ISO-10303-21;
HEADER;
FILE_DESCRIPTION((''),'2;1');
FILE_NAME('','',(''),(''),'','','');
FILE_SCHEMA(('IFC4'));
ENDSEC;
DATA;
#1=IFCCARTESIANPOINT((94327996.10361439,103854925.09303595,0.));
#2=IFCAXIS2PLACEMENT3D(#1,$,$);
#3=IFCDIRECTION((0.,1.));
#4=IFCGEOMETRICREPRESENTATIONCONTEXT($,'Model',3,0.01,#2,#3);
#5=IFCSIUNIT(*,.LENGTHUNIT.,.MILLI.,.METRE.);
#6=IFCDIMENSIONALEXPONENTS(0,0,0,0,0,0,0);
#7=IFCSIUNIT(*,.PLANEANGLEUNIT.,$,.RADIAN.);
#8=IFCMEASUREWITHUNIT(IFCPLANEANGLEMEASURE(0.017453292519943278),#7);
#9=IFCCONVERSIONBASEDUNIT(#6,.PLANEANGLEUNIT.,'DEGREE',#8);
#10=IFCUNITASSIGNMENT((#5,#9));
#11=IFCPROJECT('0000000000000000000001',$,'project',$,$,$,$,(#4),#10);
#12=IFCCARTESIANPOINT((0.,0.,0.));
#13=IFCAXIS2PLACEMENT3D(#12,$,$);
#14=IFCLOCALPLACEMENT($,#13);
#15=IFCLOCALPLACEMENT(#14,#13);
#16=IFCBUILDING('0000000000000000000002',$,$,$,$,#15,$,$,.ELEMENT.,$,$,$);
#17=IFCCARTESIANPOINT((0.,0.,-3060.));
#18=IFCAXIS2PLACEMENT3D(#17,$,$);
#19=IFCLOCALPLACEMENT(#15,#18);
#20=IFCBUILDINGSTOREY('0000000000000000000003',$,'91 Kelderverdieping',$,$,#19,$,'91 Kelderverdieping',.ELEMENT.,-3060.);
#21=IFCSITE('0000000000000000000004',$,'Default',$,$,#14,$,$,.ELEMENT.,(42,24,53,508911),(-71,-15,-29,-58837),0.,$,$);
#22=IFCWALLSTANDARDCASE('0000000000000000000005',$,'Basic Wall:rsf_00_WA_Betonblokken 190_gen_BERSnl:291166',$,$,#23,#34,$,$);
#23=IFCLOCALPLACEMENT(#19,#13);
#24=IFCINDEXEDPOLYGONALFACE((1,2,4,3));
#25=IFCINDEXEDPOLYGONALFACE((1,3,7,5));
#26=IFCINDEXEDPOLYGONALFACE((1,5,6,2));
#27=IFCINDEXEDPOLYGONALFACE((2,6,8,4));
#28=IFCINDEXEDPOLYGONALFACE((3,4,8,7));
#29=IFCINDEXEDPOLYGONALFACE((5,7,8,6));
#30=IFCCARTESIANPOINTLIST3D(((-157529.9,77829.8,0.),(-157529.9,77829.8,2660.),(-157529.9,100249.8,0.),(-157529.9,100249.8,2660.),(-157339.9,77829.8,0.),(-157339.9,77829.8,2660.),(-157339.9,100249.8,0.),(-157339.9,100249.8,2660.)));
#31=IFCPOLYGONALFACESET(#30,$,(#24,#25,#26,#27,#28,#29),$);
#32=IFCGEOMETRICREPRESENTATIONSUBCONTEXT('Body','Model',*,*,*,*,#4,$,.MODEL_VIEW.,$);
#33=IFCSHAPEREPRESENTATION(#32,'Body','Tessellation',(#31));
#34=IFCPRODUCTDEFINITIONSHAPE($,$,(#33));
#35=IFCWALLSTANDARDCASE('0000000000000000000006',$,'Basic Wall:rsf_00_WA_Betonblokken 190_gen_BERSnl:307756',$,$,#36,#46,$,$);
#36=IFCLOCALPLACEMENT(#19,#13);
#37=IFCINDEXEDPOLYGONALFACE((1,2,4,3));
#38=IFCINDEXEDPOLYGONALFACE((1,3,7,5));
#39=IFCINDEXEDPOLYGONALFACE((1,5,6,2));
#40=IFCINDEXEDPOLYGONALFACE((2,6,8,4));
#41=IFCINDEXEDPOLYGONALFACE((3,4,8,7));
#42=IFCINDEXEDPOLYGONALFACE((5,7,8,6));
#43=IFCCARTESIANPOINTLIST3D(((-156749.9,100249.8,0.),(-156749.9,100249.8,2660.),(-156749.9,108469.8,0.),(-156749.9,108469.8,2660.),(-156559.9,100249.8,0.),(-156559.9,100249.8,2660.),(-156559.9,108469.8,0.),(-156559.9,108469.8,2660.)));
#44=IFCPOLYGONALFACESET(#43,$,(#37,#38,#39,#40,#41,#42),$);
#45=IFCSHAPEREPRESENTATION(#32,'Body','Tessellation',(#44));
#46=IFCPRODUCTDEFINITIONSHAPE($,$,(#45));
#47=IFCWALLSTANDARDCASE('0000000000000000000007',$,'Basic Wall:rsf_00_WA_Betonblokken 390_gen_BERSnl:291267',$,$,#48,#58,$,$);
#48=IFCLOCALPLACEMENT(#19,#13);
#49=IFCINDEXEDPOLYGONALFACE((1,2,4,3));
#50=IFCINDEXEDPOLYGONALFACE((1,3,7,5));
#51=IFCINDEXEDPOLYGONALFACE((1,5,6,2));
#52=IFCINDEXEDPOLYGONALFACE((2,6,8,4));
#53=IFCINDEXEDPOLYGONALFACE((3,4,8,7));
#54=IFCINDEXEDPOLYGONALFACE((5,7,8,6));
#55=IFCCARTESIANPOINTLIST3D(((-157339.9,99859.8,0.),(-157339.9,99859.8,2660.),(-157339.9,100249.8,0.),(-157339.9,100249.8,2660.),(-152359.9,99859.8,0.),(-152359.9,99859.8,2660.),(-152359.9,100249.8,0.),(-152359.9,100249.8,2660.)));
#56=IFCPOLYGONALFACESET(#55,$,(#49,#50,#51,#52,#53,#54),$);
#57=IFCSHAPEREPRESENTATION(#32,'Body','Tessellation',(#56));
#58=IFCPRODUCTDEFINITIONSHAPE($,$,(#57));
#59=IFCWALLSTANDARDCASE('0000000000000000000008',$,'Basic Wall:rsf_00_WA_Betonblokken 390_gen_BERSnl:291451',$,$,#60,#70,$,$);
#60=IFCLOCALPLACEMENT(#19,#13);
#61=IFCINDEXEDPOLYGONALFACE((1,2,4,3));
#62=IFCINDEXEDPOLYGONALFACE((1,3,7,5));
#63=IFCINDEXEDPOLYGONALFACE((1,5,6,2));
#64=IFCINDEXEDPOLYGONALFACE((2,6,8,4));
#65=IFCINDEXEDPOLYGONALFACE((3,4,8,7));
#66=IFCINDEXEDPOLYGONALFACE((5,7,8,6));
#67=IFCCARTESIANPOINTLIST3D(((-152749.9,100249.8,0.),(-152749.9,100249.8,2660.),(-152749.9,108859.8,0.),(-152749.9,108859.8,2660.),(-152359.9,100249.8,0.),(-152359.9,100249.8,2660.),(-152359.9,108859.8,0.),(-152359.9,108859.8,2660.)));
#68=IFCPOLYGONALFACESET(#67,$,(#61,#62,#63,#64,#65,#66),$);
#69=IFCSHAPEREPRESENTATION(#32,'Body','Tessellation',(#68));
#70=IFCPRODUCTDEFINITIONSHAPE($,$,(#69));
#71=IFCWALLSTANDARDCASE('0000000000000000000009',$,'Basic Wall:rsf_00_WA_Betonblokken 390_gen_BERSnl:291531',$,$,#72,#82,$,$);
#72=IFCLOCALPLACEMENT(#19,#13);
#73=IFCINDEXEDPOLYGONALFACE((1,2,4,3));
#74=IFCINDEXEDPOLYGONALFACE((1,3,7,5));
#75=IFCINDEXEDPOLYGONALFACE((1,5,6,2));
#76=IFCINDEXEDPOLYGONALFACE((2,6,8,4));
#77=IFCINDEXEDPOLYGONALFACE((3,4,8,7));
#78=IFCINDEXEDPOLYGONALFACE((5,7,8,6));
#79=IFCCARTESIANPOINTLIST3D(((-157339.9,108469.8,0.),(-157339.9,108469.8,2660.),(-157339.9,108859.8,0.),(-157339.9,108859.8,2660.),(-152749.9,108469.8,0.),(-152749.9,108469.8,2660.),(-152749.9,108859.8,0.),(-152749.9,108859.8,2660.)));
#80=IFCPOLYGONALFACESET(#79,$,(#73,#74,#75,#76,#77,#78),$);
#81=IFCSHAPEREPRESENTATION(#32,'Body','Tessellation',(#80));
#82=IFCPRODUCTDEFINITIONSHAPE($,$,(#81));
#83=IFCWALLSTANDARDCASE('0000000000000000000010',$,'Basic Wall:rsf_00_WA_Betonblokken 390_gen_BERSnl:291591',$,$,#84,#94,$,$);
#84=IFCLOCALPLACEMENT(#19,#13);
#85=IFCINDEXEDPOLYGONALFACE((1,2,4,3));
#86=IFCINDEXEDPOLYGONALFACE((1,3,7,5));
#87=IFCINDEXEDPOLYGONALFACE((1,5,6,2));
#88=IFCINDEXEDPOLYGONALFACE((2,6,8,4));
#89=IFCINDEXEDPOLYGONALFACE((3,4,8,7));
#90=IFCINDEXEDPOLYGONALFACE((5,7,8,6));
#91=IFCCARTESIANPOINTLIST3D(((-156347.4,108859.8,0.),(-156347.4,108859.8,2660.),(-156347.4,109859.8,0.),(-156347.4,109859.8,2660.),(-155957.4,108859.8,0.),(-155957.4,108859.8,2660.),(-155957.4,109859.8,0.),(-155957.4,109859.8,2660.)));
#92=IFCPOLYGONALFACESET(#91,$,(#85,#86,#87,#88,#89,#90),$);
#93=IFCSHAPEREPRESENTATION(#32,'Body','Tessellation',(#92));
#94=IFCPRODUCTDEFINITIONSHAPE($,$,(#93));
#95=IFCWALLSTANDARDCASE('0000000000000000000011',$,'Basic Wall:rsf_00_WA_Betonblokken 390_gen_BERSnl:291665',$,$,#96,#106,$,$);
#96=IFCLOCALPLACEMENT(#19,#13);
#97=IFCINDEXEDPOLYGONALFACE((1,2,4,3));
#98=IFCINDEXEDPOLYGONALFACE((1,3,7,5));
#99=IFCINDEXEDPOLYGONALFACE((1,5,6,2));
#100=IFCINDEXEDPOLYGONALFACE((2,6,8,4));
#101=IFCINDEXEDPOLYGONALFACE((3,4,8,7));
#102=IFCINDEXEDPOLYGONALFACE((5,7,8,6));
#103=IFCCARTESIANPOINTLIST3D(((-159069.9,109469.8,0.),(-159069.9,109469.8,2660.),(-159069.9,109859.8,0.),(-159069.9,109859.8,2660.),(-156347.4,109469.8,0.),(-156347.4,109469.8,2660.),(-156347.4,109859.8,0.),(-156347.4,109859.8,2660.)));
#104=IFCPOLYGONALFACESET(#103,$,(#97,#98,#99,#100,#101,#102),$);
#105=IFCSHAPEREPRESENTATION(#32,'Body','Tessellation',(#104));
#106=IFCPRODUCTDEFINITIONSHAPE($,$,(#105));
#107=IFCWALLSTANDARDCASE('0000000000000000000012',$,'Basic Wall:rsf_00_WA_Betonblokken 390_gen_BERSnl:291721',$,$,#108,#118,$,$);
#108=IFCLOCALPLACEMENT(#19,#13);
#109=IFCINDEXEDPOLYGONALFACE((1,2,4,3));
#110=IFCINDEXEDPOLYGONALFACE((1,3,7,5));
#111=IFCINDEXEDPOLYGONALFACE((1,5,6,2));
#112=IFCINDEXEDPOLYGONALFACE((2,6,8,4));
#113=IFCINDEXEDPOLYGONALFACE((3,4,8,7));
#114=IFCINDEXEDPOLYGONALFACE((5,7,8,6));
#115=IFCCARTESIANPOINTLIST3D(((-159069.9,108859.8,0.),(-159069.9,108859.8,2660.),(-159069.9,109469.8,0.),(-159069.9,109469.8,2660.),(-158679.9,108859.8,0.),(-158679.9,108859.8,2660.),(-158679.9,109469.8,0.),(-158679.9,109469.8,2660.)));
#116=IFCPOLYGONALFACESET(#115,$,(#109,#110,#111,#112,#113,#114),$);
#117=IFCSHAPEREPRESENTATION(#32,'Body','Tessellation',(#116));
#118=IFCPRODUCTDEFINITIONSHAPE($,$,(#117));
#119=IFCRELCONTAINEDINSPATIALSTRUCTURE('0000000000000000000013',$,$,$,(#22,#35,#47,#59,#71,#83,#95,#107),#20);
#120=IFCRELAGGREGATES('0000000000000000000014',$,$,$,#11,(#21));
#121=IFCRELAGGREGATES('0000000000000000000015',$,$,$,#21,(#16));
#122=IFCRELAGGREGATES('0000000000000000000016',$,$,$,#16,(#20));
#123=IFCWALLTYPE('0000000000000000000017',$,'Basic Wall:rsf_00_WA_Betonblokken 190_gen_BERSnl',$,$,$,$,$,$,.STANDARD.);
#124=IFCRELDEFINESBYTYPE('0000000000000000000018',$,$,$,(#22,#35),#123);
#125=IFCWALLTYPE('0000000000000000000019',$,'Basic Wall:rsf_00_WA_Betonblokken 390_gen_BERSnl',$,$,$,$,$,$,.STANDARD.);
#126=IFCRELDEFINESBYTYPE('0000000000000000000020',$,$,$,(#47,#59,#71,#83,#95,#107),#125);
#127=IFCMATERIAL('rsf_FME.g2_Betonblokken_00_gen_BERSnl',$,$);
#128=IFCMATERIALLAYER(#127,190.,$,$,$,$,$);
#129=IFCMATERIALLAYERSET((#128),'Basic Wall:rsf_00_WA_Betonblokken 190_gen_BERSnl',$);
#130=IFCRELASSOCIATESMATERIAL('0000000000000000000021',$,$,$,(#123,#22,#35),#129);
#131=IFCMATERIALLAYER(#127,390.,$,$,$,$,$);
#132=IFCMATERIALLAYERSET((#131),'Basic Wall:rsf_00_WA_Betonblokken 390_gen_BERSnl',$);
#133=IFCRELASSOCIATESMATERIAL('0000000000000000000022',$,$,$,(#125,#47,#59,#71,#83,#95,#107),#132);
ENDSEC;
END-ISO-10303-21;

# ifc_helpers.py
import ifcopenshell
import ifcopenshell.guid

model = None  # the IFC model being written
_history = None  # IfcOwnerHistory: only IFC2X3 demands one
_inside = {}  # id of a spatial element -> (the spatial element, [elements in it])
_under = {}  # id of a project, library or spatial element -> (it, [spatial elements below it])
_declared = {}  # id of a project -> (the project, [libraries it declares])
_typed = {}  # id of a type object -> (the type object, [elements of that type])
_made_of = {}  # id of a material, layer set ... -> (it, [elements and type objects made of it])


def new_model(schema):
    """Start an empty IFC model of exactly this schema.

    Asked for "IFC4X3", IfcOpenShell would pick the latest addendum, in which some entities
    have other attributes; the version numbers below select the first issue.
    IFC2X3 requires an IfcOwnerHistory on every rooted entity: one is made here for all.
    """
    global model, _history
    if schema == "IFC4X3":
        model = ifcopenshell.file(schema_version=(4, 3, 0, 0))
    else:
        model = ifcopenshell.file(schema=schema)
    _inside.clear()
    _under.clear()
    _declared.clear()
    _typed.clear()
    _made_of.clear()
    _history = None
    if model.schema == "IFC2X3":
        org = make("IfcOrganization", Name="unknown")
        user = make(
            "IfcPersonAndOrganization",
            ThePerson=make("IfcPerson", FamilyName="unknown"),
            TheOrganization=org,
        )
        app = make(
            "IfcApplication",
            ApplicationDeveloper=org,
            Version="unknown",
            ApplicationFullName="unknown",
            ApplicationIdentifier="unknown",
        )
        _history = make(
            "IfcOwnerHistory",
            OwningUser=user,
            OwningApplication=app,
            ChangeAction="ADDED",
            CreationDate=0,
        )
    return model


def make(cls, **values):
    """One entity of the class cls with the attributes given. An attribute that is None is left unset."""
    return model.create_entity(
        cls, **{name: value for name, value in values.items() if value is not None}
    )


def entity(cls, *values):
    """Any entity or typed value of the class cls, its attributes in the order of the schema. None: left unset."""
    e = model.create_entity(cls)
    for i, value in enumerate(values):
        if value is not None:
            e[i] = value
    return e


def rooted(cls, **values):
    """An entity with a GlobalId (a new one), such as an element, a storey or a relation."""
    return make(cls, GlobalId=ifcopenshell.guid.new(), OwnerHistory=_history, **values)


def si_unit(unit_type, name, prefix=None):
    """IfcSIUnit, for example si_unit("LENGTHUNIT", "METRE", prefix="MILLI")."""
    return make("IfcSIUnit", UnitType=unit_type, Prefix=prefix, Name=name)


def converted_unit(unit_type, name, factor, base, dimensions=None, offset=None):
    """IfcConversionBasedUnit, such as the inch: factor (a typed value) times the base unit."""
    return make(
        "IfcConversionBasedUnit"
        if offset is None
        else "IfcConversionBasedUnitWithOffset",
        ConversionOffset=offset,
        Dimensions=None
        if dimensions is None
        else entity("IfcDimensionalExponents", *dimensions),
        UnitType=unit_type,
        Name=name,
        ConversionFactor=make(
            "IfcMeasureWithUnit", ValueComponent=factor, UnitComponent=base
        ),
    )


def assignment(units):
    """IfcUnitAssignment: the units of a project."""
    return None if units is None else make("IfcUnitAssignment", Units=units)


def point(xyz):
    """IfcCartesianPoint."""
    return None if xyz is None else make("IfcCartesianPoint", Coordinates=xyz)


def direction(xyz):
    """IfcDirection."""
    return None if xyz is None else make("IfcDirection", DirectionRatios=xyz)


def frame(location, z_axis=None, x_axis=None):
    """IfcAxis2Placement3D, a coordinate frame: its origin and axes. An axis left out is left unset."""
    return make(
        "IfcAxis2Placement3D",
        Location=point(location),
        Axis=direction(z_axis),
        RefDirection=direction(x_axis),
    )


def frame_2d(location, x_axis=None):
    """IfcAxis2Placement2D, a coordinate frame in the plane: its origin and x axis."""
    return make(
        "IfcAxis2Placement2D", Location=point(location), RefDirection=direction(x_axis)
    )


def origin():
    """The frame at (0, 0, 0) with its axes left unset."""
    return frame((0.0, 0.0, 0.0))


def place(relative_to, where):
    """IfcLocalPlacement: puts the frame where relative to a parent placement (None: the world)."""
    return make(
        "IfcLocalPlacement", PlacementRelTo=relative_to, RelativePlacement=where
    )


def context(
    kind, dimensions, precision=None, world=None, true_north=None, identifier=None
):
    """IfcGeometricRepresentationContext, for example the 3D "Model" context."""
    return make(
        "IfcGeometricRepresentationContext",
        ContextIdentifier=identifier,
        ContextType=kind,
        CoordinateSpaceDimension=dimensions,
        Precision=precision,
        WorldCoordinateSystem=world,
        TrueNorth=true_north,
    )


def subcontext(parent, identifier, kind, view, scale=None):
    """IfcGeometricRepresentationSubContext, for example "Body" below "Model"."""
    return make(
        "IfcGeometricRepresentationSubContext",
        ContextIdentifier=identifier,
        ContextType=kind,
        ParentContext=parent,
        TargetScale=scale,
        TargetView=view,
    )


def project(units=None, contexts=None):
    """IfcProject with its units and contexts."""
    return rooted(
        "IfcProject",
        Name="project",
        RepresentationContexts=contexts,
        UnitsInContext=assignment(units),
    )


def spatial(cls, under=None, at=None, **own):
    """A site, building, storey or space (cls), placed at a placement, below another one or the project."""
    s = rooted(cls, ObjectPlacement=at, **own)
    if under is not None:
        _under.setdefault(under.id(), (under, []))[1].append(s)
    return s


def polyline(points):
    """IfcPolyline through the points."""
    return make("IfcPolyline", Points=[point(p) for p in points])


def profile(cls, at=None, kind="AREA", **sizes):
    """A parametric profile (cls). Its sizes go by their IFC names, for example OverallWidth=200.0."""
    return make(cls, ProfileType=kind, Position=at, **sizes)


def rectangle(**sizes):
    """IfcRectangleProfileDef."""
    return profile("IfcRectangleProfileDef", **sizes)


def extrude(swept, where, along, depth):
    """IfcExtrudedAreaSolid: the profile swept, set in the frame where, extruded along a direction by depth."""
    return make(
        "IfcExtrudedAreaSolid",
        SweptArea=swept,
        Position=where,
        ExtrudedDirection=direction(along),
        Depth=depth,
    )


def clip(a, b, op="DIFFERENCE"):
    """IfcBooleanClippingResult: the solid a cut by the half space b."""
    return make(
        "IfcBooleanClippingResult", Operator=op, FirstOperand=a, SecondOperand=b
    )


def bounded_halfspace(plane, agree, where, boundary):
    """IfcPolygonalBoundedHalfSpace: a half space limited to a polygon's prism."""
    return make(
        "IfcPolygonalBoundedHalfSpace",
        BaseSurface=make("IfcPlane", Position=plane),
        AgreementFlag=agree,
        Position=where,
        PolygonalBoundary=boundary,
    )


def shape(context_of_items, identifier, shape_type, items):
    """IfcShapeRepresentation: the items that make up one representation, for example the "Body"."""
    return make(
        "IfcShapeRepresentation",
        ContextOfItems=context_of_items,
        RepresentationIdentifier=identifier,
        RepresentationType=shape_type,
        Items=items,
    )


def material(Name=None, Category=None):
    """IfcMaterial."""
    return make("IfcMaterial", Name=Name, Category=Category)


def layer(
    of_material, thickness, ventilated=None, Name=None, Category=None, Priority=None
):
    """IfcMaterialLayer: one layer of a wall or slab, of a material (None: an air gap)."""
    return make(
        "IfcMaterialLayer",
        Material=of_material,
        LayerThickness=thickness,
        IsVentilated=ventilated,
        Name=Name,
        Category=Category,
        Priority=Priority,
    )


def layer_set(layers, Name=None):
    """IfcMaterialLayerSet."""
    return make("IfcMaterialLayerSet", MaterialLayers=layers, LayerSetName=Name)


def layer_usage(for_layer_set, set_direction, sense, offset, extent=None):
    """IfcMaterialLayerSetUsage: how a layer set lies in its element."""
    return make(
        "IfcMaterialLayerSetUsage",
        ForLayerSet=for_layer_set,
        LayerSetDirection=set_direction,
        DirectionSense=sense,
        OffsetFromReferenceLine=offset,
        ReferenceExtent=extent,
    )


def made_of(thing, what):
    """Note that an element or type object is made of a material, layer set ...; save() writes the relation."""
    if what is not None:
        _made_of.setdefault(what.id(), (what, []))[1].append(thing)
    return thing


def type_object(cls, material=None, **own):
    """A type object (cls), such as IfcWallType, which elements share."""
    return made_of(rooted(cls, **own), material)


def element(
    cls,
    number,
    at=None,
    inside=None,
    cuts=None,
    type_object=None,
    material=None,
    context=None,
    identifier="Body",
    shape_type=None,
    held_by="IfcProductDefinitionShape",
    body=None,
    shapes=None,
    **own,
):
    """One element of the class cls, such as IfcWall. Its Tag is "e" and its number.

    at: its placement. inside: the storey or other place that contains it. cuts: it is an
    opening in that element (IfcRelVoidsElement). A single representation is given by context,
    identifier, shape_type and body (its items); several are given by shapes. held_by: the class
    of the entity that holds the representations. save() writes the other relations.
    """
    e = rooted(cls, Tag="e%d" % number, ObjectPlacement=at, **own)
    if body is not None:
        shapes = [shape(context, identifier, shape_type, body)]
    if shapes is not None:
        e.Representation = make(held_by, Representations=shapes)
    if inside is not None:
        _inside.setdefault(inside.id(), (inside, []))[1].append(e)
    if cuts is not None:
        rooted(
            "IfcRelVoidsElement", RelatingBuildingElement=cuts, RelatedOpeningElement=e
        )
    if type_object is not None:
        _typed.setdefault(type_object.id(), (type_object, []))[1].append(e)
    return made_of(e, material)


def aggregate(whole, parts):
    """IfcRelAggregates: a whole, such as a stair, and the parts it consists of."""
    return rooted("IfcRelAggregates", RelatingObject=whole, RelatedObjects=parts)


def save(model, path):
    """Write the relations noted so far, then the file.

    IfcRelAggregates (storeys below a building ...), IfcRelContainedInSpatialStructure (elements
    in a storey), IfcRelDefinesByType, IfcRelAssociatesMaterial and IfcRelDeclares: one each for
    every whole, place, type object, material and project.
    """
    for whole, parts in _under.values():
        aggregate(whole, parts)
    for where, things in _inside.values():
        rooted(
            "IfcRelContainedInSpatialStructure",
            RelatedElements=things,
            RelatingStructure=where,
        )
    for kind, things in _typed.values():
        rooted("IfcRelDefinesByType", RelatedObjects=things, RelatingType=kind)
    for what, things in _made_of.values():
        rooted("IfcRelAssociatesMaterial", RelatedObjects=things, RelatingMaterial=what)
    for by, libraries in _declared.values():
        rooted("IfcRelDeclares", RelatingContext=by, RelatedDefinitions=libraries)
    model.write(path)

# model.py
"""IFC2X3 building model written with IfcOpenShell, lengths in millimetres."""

from ifc_helpers import new_model, entity, si_unit, converted_unit, direction, frame, frame_2d, origin, place, context, subcontext, project, spatial, polyline, rectangle, extrude, clip, bounded_halfspace, material, layer, layer_set, layer_usage, type_object, element, save


model = new_model("IFC2X3")

# Units and contexts
model_context = context("Model", 3, precision=0.01, world=frame((94327996.10361439, 103854925.09303595, 0.0)), true_north=direction((0.0, 1.0)))
body_context = subcontext(model_context, "Body", "Model", "MODEL_VIEW")
ifc_project = project(units=[si_unit("LENGTHUNIT", "METRE", prefix="MILLI"), converted_unit("PLANEANGLEUNIT", "DEGREE", entity("IfcPlaneAngleMeasure", 0.017453292519943278), si_unit("PLANEANGLEUNIT", "RADIAN"), dimensions=[0, 0, 0, 0, 0, 0, 0])], contexts=[model_context])

# Site, building, storey
site_placement = place(None, origin())
site = spatial("IfcSite", under=ifc_project, at=site_placement, Name="Default", CompositionType="ELEMENT", RefLatitude=(42, 24, 53, 508911), RefLongitude=(-71, -15, -29, -58837), RefElevation=0.0)
building_placement = place(site_placement, origin())
building = spatial("IfcBuilding", under=site, at=building_placement, CompositionType="ELEMENT")
storey_placement = place(building_placement, frame((0.0, 0.0, -3060.0)))
storey = spatial("IfcBuildingStorey", under=building, at=storey_placement, Name="91 Kelderverdieping", LongName="91 Kelderverdieping", CompositionType="ELEMENT", Elevation=-3060.0)

# Walls
ifc_material_1 = material(Name="rsf_FME.g2_Betonblokken_00_gen_BERSnl")
ifc_layer_1 = layer(ifc_material_1, 190.0)
ifc_layer_set_1 = layer_set([ifc_layer_1], Name="Basic Wall:rsf_00_WA_Betonblokken 190_gen_BERSnl")
wall_type_1 = type_object("IfcWallType", Name="Basic Wall:rsf_00_WA_Betonblokken 190_gen_BERSnl", PredefinedType="STANDARD", material=ifc_layer_set_1)
ifc_layer_usage_1 = layer_usage(ifc_layer_set_1, "AXIS2", "POSITIVE", -95.0)
wall_1_placement = place(storey_placement, frame((-157434.9, 77829.8, 0.0), z_axis=(0.0, 0.0, 1.0), x_axis=(0.0, 1.0, 0.0)))
element("IfcWallStandardCase", 1, at=wall_1_placement, inside=storey, type_object=wall_type_1, material=ifc_layer_usage_1, Name="Basic Wall:rsf_00_WA_Betonblokken 190_gen_BERSnl:291166", context=body_context, shape_type="Clipping", body=[
    clip(extrude(rectangle(XDim=22420.0, YDim=190.0, at=frame_2d((11210.0, 0.0), x_axis=(-1.0, 0.0))), origin(), (0.0, 0.0, 1.0), 2660.0), bounded_halfspace(frame((0.0, -95.0, 2660.0), z_axis=(0.0, 0.0, -1.0), x_axis=(0.0, 1.0, 0.0)), True, frame((0.0, -95.0, 2660.0)), polyline([(0.0, 0.0), (22020.0, 0.0), (22030.0, 0.0), (22420.0, 0.0), (22420.0, 190.0), (0.0, 190.0), (0.0, 0.0)]))),
])
ifc_layer_usage_2 = layer_usage(ifc_layer_set_1, "AXIS2", "NEGATIVE", 95.0)
wall_2_placement = place(storey_placement, frame((-156654.9, 100249.8, 0.0), z_axis=(0.0, 0.0, 1.0), x_axis=(0.0, 1.0, 0.0)))
element("IfcWallStandardCase", 2, at=wall_2_placement, inside=storey, type_object=wall_type_1, material=ifc_layer_usage_2, Name="Basic Wall:rsf_00_WA_Betonblokken 190_gen_BERSnl:307756", context=body_context, shape_type="SweptSolid", body=[
    extrude(rectangle(XDim=8220.0, YDim=190.0, at=frame_2d((4110.0, 0.0), x_axis=(-1.0, 0.0))), origin(), (0.0, 0.0, 1.0), 2660.0),
])
ifc_layer_2 = layer(ifc_material_1, 390.0)
ifc_layer_set_2 = layer_set([ifc_layer_2], Name="Basic Wall:rsf_00_WA_Betonblokken 390_gen_BERSnl")
ifc_layer_usage_3 = layer_usage(ifc_layer_set_2, "AXIS2", "POSITIVE", -195.0)
wall_type_2 = type_object("IfcWallType", Name="Basic Wall:rsf_00_WA_Betonblokken 390_gen_BERSnl", PredefinedType="STANDARD", material=ifc_layer_set_2)
wall_3_placement = place(storey_placement, frame((-157339.9, 100054.8, 0.0)))
element("IfcWallStandardCase", 3, at=wall_3_placement, inside=storey, type_object=wall_type_2, material=ifc_layer_usage_3, Name="Basic Wall:rsf_00_WA_Betonblokken 390_gen_BERSnl:291267", context=body_context, shape_type="Clipping", body=[
    clip(extrude(rectangle(XDim=4980.0, YDim=390.0, at=frame_2d((2490.0, 0.0), x_axis=(-1.0, 0.0))), origin(), (0.0, 0.0, 1.0), 2660.0), bounded_halfspace(frame((0.0, -195.0, 2660.0), z_axis=(0.0, 0.0, -1.0), x_axis=(-1.0, 0.0, 0.0)), True, frame((0.0, -195.0, 2660.0)), polyline([(0.0, 0.0), (4980.0, 0.0), (4980.0, 390.0), (4590.0, 390.0), (0.0, 390.0), (0.0, 0.0)]))),
])
ifc_layer_usage_4 = layer_usage(ifc_layer_set_2, "AXIS2", "POSITIVE", -195.0)
wall_4_placement = place(storey_placement, frame((-152554.9, 100249.8, 0.0), z_axis=(0.0, 0.0, 1.0), x_axis=(0.0, 1.0, 0.0)))
element("IfcWallStandardCase", 4, at=wall_4_placement, inside=storey, type_object=wall_type_2, material=ifc_layer_usage_4, Name="Basic Wall:rsf_00_WA_Betonblokken 390_gen_BERSnl:291451", context=body_context, shape_type="Clipping", body=[
    clip(extrude(rectangle(XDim=8610.0, YDim=390.0, at=frame_2d((4305.0, 0.0), x_axis=(-1.0, 0.0))), origin(), (0.0, 0.0, 1.0), 2660.0), bounded_halfspace(frame((0.0, -195.0, 2660.0), z_axis=(0.0, 0.0, -1.0), x_axis=(0.0, 1.0, 0.0)), True, frame((0.0, -195.0, 2660.0)), polyline([(0.0, 0.0), (8610.0, 0.0), (8610.0, 190.0), (8610.0, 390.0), (8220.0, 390.0), (0.0, 390.0), (0.0, 0.0)]))),
])
ifc_layer_usage_5 = layer_usage(ifc_layer_set_2, "AXIS2", "POSITIVE", -195.0)
wall_5_placement = place(storey_placement, frame((-152749.9, 108664.8, 0.0), z_axis=(0.0, 0.0, 1.0), x_axis=(-1.0, 0.0, 0.0)))
element("IfcWallStandardCase", 5, at=wall_5_placement, inside=storey, type_object=wall_type_2, material=ifc_layer_usage_5, Name="Basic Wall:rsf_00_WA_Betonblokken 390_gen_BERSnl:291531", context=body_context, shape_type="Clipping", body=[
    clip(extrude(rectangle(XDim=4590.0, YDim=390.0, at=frame_2d((2295.0, 0.0), x_axis=(-1.0, 0.0))), origin(), (0.0, 0.0, 1.0), 2660.0), bounded_halfspace(frame((0.0, -195.0, 2660.0), z_axis=(0.0, 0.0, -1.0), x_axis=(1.0, 0.0, 0.0)), True, frame((0.0, -195.0, 2660.0)), polyline([(0.0, 0.0), (3207.5, 0.0), (3597.5, 0.0), (4590.0, 0.0), (4590.0, 390.0), (0.0, 390.0), (0.0, 0.0)]))),
])
ifc_layer_usage_6 = layer_usage(ifc_layer_set_2, "AXIS2", "POSITIVE", -195.0)
wall_6_placement = place(storey_placement, frame((-156152.4, 108859.8, 0.0), z_axis=(0.0, 0.0, 1.0), x_axis=(0.0, 1.0, 0.0)))
element("IfcWallStandardCase", 6, at=wall_6_placement, inside=storey, type_object=wall_type_2, material=ifc_layer_usage_6, Name="Basic Wall:rsf_00_WA_Betonblokken 390_gen_BERSnl:291591", context=body_context, shape_type="Clipping", body=[
    clip(extrude(rectangle(XDim=1000.0, YDim=390.0, at=frame_2d((500.0, 0.0), x_axis=(-1.0, 0.0))), origin(), (0.0, 0.0, 1.0), 2660.0), bounded_halfspace(frame((0.0, -195.0, 2660.0), z_axis=(0.0, 0.0, -1.0), x_axis=(0.0, 1.0, 0.0)), True, frame((0.0, -195.0, 2660.0)), polyline([(0.0, 0.0), (1000.0, 0.0), (1000.0, 390.0), (610.0, 390.0), (0.0, 390.0), (0.0, 0.0)]))),
])
ifc_layer_usage_7 = layer_usage(ifc_layer_set_2, "AXIS2", "POSITIVE", -195.0)
wall_7_placement = place(storey_placement, frame((-156347.4, 109664.8, 0.0), z_axis=(0.0, 0.0, 1.0), x_axis=(-1.0, 0.0, 0.0)))
element("IfcWallStandardCase", 7, at=wall_7_placement, inside=storey, type_object=wall_type_2, material=ifc_layer_usage_7, Name="Basic Wall:rsf_00_WA_Betonblokken 390_gen_BERSnl:291665", context=body_context, shape_type="Clipping", body=[
    clip(extrude(rectangle(XDim=2722.5, YDim=390.0, at=frame_2d((1361.3, 0.0), x_axis=(-1.0, 0.0))), origin(), (0.0, 0.0, 1.0), 2660.0), bounded_halfspace(frame((0.0, -195.0, 2660.0), z_axis=(0.0, 0.0, -1.0), x_axis=(1.0, 0.0, 0.0)), True, frame((0.0, -195.0, 2660.0)), polyline([(0.0, 0.0), (2532.5, 0.0), (2722.5, 0.0), (2722.5, 390.0), (2332.5, 390.0), (0.0, 390.0), (0.0, 0.0)]))),
])
ifc_layer_usage_8 = layer_usage(ifc_layer_set_2, "AXIS2", "POSITIVE", -195.0)
wall_8_placement = place(storey_placement, frame((-158874.9, 109469.8, 0.0), z_axis=(0.0, 0.0, 1.0), x_axis=(0.0, -1.0, 0.0)))
element("IfcWallStandardCase", 8, at=wall_8_placement, inside=storey, type_object=wall_type_2, material=ifc_layer_usage_8, Name="Basic Wall:rsf_00_WA_Betonblokken 390_gen_BERSnl:291721", context=body_context, shape_type="Clipping", body=[
    clip(extrude(rectangle(XDim=610.0, YDim=390.0, at=frame_2d((305.0, 0.0), x_axis=(-1.0, 0.0))), origin(), (0.0, 0.0, 1.0), 2660.0), bounded_halfspace(frame((0.0, -195.0, 2660.0), z_axis=(0.0, 0.0, -1.0), x_axis=(0.0, -1.0, 0.0)), True, frame((0.0, -195.0, 2660.0)), polyline([(0.0, 0.0), (610.0, 0.0), (610.0, 390.0), (0.0, 390.0), (0.0, 0.0)]))),
])

save(model, "model.ifc")
